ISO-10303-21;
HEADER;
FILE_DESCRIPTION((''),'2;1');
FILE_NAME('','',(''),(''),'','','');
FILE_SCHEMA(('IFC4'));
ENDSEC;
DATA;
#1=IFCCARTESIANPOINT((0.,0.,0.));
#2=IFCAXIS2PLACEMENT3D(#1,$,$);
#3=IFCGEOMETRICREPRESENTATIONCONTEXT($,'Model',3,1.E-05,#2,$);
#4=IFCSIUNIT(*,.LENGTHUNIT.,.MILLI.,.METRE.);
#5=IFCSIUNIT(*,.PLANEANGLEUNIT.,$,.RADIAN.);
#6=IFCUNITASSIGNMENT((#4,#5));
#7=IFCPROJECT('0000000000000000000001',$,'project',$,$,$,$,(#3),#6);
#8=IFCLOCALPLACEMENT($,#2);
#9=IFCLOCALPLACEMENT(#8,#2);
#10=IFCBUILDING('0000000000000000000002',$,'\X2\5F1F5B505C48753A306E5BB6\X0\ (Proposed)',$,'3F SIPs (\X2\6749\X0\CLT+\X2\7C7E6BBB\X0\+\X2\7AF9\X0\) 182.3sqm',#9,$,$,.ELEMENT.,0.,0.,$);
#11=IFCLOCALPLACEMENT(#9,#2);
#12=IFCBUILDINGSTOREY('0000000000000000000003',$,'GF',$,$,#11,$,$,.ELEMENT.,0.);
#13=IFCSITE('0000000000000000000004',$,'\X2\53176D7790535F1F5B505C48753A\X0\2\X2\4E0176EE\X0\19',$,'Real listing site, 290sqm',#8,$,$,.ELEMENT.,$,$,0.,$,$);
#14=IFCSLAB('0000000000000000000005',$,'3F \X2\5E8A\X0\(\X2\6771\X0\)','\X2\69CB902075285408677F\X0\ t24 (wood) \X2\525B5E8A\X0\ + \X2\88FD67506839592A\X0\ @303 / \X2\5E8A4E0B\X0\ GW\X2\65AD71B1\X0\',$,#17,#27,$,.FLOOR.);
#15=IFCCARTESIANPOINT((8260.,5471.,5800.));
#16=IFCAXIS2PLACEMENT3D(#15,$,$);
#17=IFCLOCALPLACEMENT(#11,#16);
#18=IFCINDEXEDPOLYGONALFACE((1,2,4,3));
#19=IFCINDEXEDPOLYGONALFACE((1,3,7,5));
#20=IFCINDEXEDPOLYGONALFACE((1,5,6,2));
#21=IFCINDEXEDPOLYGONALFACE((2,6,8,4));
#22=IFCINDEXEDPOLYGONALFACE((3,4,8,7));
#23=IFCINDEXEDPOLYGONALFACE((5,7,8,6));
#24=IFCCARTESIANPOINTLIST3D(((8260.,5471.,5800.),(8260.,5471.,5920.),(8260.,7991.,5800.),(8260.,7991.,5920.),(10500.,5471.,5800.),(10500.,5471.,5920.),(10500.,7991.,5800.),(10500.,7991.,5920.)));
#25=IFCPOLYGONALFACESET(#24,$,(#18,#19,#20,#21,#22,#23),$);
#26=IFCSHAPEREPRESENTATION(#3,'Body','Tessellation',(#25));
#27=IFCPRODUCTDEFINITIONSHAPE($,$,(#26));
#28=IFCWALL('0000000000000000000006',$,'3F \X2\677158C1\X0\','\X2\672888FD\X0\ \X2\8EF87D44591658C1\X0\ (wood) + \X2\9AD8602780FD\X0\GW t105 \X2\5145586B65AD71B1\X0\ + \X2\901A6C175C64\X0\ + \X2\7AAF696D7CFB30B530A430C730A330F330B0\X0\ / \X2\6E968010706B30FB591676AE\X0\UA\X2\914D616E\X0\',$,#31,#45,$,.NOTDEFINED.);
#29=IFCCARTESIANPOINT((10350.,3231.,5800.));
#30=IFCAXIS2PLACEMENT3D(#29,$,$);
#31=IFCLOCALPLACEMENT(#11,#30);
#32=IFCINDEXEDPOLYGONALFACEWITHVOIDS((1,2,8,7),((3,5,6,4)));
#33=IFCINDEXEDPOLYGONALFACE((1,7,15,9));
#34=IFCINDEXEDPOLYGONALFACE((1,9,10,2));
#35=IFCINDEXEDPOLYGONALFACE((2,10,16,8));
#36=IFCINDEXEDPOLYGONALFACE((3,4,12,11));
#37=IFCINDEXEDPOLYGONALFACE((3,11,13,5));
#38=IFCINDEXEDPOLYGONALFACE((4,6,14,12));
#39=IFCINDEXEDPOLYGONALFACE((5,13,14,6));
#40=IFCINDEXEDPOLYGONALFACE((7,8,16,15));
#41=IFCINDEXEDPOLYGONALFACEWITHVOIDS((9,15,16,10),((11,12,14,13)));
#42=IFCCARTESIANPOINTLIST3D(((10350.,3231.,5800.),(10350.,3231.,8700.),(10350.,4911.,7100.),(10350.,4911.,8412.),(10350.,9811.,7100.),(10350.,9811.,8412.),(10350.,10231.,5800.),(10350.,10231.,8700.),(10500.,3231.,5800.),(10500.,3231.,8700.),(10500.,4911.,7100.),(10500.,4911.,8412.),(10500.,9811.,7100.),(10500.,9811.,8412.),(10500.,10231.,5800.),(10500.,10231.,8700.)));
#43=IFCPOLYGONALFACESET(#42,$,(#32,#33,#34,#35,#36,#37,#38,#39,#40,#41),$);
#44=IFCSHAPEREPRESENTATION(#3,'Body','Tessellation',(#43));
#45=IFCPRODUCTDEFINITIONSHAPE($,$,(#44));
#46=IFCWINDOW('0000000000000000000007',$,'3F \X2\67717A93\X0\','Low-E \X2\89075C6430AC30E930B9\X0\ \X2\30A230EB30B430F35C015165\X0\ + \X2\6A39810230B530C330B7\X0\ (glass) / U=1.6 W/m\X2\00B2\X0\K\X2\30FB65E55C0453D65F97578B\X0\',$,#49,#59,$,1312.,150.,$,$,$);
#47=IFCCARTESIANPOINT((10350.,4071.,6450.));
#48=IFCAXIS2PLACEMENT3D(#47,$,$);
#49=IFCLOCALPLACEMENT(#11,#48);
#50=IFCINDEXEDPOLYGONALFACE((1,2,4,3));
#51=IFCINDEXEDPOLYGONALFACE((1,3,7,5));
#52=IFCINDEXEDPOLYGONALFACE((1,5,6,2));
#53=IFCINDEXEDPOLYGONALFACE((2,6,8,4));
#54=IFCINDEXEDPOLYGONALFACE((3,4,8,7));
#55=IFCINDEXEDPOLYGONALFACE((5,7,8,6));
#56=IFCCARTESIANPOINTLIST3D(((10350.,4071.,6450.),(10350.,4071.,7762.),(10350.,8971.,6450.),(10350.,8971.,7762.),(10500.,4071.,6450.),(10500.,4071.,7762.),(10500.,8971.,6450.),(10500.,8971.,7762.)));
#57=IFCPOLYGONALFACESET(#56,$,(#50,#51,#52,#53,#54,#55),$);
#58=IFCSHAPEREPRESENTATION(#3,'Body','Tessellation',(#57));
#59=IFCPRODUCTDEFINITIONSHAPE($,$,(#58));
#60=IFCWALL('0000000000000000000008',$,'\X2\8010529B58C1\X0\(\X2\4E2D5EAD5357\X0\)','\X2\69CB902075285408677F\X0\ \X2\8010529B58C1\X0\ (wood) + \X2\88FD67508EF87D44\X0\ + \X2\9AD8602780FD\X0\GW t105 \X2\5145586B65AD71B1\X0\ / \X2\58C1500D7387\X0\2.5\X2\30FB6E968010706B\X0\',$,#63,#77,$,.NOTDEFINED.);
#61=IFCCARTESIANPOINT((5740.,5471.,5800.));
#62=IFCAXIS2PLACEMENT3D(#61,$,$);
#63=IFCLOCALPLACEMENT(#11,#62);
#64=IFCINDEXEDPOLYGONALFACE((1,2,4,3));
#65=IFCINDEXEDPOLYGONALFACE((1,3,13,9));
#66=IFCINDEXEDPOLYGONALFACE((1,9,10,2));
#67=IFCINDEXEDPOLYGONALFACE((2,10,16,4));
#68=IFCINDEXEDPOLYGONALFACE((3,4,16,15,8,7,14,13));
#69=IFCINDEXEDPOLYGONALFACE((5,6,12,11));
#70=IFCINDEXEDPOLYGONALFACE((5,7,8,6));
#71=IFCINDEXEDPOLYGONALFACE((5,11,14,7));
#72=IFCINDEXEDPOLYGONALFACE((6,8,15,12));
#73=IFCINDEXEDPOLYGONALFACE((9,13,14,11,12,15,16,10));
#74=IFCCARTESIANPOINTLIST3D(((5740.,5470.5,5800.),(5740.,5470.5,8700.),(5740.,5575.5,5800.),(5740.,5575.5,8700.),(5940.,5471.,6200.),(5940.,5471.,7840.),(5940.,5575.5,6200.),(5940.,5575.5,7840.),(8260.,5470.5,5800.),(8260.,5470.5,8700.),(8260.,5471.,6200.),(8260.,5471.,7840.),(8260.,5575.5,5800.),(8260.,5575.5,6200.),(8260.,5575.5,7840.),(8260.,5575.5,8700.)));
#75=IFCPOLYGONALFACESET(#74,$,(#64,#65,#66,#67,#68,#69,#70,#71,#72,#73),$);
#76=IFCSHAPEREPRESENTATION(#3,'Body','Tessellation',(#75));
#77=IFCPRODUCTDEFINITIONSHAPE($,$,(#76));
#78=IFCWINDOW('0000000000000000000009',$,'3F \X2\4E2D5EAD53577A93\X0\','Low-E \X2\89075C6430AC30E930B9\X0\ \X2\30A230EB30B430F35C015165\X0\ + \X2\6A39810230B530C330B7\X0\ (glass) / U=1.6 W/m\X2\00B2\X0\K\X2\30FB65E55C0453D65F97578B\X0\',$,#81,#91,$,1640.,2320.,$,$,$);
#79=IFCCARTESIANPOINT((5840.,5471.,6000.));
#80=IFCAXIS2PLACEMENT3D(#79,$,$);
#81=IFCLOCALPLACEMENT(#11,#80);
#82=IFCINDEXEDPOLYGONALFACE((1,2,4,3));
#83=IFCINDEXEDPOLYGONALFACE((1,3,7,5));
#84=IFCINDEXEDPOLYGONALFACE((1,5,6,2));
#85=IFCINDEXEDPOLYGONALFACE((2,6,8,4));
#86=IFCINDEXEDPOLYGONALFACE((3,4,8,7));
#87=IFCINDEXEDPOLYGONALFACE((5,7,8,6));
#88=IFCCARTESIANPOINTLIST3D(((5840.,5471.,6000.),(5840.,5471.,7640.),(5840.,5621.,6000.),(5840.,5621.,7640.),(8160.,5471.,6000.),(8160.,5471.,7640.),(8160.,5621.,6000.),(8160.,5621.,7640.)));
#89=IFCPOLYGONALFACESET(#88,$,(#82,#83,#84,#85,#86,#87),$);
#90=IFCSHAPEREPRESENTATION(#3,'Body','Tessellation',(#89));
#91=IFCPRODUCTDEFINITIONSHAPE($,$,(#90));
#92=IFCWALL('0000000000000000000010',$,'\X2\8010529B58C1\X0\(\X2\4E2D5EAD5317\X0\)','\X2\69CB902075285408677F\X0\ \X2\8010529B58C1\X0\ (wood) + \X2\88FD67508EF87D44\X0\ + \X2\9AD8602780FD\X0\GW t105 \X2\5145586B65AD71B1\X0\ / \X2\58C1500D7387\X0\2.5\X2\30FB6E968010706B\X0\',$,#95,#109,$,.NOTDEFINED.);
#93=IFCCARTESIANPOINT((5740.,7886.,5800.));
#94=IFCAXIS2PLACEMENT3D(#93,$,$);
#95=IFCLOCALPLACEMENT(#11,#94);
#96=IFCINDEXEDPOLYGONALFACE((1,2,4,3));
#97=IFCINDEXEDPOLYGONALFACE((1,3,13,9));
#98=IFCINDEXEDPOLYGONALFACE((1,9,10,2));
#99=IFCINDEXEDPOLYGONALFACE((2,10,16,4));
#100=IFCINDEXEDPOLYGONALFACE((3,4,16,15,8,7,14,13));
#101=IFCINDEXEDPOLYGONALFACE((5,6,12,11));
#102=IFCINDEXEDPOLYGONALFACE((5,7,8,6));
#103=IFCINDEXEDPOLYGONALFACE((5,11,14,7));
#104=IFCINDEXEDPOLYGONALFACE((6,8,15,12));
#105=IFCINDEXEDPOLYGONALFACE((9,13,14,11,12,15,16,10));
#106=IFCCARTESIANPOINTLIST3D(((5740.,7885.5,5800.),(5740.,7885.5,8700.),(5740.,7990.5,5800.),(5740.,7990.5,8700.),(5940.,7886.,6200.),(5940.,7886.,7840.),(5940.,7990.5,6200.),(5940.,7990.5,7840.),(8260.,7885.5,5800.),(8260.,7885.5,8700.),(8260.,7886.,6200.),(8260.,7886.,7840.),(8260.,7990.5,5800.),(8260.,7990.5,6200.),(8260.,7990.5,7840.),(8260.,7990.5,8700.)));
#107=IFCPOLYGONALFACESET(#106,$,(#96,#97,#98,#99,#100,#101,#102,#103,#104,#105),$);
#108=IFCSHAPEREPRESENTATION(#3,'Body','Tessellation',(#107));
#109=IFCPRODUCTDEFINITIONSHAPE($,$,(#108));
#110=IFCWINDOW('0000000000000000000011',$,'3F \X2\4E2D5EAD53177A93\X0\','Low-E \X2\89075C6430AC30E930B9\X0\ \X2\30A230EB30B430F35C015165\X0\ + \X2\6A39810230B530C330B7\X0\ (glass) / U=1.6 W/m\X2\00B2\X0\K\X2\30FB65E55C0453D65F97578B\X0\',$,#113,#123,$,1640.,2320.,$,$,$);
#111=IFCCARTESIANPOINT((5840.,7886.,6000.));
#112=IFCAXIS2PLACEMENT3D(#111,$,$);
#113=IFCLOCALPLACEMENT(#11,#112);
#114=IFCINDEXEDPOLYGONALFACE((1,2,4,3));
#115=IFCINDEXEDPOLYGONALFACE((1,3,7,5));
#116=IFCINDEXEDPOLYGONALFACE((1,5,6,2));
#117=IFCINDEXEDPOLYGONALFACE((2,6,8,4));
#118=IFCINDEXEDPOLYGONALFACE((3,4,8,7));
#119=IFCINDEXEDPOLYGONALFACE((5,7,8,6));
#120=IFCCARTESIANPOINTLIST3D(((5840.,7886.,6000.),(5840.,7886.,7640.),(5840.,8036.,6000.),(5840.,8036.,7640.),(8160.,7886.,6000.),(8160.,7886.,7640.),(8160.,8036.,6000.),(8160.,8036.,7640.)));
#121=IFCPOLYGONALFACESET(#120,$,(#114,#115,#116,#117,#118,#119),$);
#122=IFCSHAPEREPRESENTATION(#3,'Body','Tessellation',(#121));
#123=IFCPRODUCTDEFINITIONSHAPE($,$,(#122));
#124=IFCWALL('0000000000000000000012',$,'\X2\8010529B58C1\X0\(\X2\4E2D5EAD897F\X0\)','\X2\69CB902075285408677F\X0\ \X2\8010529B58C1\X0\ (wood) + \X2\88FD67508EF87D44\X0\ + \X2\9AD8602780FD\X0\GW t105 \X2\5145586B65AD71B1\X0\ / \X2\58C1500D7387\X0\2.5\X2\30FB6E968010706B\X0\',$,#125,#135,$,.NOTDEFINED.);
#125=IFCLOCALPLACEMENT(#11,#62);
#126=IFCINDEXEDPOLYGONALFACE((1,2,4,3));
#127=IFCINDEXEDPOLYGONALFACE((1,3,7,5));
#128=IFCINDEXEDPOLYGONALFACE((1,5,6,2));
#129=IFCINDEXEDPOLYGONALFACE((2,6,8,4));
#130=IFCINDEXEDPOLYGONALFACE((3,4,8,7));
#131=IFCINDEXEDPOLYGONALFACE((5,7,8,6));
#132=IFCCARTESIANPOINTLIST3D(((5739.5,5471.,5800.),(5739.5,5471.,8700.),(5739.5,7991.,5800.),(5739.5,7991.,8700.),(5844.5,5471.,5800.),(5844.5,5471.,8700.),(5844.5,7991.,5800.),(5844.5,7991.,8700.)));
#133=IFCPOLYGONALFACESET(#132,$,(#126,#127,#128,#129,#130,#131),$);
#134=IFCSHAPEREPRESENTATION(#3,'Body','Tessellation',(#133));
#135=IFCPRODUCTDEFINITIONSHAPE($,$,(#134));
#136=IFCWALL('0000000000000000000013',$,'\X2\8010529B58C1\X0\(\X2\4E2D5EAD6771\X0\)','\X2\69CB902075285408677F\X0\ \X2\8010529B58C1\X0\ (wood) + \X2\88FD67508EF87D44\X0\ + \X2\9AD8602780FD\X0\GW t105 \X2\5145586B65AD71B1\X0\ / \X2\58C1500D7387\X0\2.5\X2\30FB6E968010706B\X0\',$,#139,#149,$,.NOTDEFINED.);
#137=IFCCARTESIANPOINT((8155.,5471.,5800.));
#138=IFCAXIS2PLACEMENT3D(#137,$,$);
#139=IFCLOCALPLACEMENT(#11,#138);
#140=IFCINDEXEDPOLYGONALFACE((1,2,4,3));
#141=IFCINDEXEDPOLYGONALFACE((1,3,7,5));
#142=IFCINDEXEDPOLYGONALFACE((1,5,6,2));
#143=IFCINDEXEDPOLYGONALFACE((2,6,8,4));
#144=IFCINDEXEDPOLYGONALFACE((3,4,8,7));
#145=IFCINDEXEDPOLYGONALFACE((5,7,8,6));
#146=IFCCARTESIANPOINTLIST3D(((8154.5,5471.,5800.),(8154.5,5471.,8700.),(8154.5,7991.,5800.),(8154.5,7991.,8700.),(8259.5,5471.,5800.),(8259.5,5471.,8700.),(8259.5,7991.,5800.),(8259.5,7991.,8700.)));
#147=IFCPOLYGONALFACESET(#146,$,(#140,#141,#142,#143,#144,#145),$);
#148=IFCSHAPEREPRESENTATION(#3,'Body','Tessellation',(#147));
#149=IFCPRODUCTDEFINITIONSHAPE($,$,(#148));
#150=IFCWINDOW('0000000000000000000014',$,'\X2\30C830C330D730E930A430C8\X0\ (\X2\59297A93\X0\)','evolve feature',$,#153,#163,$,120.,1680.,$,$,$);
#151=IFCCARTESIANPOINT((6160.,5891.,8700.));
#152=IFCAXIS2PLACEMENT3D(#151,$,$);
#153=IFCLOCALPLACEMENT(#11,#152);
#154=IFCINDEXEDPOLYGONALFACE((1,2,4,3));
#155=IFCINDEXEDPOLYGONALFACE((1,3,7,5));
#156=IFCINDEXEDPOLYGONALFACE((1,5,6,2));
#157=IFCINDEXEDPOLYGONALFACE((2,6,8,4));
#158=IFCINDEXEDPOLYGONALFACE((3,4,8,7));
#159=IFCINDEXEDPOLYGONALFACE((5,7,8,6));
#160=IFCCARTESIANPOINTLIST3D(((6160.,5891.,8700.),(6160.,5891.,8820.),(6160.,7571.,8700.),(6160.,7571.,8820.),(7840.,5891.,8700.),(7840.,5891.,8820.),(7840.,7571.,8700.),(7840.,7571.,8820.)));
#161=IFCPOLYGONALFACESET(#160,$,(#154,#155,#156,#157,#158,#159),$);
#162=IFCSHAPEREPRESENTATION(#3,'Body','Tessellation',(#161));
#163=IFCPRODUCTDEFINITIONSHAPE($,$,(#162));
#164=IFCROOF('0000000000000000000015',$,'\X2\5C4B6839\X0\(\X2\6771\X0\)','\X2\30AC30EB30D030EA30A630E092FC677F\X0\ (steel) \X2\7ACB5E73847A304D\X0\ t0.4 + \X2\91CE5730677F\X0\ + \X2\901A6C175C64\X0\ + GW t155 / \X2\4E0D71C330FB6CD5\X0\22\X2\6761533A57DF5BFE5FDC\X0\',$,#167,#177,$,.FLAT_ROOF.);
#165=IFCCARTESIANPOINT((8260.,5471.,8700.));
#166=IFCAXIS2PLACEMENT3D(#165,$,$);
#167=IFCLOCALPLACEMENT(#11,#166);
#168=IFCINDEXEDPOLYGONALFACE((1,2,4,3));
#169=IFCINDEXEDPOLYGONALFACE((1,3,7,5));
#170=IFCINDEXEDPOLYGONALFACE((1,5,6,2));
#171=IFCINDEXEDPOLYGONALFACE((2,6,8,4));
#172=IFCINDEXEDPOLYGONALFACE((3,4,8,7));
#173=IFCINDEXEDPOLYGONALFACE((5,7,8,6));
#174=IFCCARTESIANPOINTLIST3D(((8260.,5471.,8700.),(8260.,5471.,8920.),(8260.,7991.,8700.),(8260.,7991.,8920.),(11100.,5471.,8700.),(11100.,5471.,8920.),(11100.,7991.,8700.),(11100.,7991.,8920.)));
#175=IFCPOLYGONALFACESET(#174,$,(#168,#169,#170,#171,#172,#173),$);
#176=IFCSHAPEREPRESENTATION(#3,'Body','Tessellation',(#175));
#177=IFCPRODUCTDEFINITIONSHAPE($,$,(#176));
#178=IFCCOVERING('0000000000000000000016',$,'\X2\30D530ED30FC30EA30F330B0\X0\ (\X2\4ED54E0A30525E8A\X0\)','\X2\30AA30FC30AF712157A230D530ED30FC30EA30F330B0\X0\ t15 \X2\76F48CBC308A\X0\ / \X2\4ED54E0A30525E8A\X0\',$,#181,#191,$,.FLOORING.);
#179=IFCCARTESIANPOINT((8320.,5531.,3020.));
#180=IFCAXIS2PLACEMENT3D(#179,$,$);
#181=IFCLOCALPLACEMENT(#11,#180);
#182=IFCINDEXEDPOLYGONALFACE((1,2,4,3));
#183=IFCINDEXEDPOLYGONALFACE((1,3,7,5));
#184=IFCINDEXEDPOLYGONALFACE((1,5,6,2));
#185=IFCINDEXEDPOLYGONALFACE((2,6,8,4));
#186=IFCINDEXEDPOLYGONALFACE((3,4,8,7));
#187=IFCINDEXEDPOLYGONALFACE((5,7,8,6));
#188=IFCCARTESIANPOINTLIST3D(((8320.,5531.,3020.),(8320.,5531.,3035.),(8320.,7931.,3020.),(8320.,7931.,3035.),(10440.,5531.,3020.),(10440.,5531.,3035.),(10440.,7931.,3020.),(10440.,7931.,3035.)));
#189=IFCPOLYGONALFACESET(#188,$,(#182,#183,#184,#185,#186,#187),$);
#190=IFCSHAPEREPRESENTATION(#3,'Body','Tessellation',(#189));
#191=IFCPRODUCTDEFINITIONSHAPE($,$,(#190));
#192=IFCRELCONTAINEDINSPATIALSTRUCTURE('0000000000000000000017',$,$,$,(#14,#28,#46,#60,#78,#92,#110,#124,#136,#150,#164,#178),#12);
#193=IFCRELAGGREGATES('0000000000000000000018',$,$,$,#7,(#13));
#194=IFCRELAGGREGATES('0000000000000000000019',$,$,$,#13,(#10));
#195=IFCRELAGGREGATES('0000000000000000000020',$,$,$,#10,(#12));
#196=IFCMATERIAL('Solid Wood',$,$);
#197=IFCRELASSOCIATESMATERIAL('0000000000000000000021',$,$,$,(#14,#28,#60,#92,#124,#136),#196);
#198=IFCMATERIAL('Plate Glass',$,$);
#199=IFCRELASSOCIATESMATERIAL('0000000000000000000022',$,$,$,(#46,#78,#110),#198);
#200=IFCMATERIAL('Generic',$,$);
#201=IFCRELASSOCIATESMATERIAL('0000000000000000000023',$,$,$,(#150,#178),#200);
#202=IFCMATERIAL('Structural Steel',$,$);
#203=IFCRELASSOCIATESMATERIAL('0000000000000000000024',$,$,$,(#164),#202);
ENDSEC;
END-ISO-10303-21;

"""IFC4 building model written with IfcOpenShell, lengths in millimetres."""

from ifc_helpers import new_model, si_unit, frame, frame_2d, origin, place, context, project, spatial, rectangle, extrude, material, element, fill, save


model = new_model("IFC4")

# Units and contexts
model_context = context("Model", 3, precision=1e-05, world=origin())
ifc_project = project(units=[si_unit("LENGTHUNIT", "METRE", prefix="MILLI"), si_unit("PLANEANGLEUNIT", "RADIAN")], contexts=[model_context])

# Site, building, storey
site_placement = place(None, origin())
site = spatial("IfcSite", under=ifc_project, at=site_placement, Name="北海道弟子屈町2丁目19", ObjectType="Real listing site, 290sqm", CompositionType="ELEMENT", RefElevation=0.0)
building_placement = place(site_placement, origin())
building = spatial("IfcBuilding", under=site, at=building_placement, Name="弟子屈町の家 (Proposed)", ObjectType="3F SIPs (杉CLT+籾殻+竹) 182.3sqm", CompositionType="ELEMENT", ElevationOfRefHeight=0.0, ElevationOfTerrain=0.0)
storey_placement = place(building_placement, origin())
storey = spatial("IfcBuildingStorey", under=building, at=storey_placement, Name="GF", CompositionType="ELEMENT", Elevation=0.0)

# Slab
ifc_material_1 = material(Name="Solid Wood")
slab_placement = place(storey_placement, frame((8260.0, 5471.0, 5800.0)))
element("IfcSlab", 1, at=slab_placement, inside=storey, material=ifc_material_1, Name="3F 床(東)", Description="構造用合板 t24 (wood) 剛床 + 製材根太 @303 / 床下 GW断熱", PredefinedType="FLOOR", context=model_context, shape_type="SweptSolid", body=[
    extrude(rectangle(XDim=2240.0, YDim=2520.0, at=frame_2d((1120.0, 1260.0))), frame((8260.0, 5471.0, 5800.0)), (0.0, 0.0, 1.0), 120.0),
])

# Walls, openings, windows
wall_1_placement = place(storey_placement, frame((10350.0, 3231.0, 5800.0)))
wall_1 = element("IfcWall", 2, at=wall_1_placement, inside=storey, material=ifc_material_1, Name="3F 東壁", Description="木製 軸組外壁 (wood) + 高性能GW t105 充填断熱 + 通気層 + 窯業系サイディング / 準耐火・外皮UA配慮", PredefinedType="NOTDEFINED", context=model_context, shape_type="SweptSolid", body=[
    extrude(rectangle(XDim=150.0, YDim=7000.0, at=frame_2d((75.0, 3500.0))), frame((10350.0, 3231.0, 5800.0)), (0.0, 0.0, 1.0), 2900.0),
])
opening_1_placement = place(storey_placement, frame((10350.0, 4071.0, 6450.0)))
opening_1 = element("IfcOpeningElement", 3, at=opening_1_placement, cuts=wall_1, PredefinedType="NOTDEFINED", context=model_context, shape_type="SweptSolid", body=[
    extrude(rectangle(XDim=150.0, YDim=4900.0, at=frame_2d((75.0, 2450.0))), frame((10350.0, 4071.0, 6450.0)), (0.0, 0.0, 1.0), 1312.0),
])
ifc_material_2 = material(Name="Plate Glass")
window_1_placement = place(storey_placement, frame((10350.0, 4071.0, 6450.0)))
window_1 = element("IfcWindow", 4, at=window_1_placement, inside=storey, material=ifc_material_2, Name="3F 東窓", Description="Low-E 複層ガラス アルゴン封入 + 樹脂サッシ (glass) / U=1.6 W/m²K・日射取得型", OverallHeight=1312.0, OverallWidth=150.0, context=model_context, shape_type="SweptSolid", body=[
    extrude(rectangle(XDim=150.0, YDim=4900.0, at=frame_2d((75.0, 2450.0))), frame((10350.0, 4071.0, 6450.0)), (0.0, 0.0, 1.0), 1312.0),
])
fill(opening_1, window_1)
wall_2_placement = place(storey_placement, frame((5740.0, 5471.0, 5800.0)))
wall_2 = element("IfcWall", 5, at=wall_2_placement, inside=storey, material=ifc_material_1, Name="耐力壁(中庭南)", Description="構造用合板 耐力壁 (wood) + 製材軸組 + 高性能GW t105 充填断熱 / 壁倍率2.5・準耐火", PredefinedType="NOTDEFINED", context=model_context, shape_type="SweptSolid", body=[
    extrude(rectangle(XDim=2520.0, YDim=105.0, at=frame_2d((1260.0, 52.0))), frame((5740.0, 5471.0, 5800.0)), (0.0, 0.0, 1.0), 2900.0),
])
opening_2_placement = place(storey_placement, frame((5840.0, 5471.0, 6000.0)))
opening_2 = element("IfcOpeningElement", 6, at=opening_2_placement, cuts=wall_2, PredefinedType="NOTDEFINED", context=model_context, shape_type="SweptSolid", body=[
    extrude(rectangle(XDim=2320.0, YDim=150.0, at=frame_2d((1160.0, 75.0))), frame((5840.0, 5471.0, 6000.0)), (0.0, 0.0, 1.0), 1640.0),
])
window_2_placement = place(storey_placement, frame((5840.0, 5471.0, 6000.0)))
window_2 = element("IfcWindow", 7, at=window_2_placement, inside=storey, material=ifc_material_2, Name="3F 中庭南窓", Description="Low-E 複層ガラス アルゴン封入 + 樹脂サッシ (glass) / U=1.6 W/m²K・日射取得型", OverallHeight=1640.0, OverallWidth=2320.0, context=model_context, shape_type="SweptSolid", body=[
    extrude(rectangle(XDim=2320.0, YDim=150.0, at=frame_2d((1160.0, 75.0))), frame((5840.0, 5471.0, 6000.0)), (0.0, 0.0, 1.0), 1640.0),
])
fill(opening_2, window_2)
wall_3_placement = place(storey_placement, frame((5740.0, 7886.0, 5800.0)))
wall_3 = element("IfcWall", 8, at=wall_3_placement, inside=storey, material=ifc_material_1, Name="耐力壁(中庭北)", Description="構造用合板 耐力壁 (wood) + 製材軸組 + 高性能GW t105 充填断熱 / 壁倍率2.5・準耐火", PredefinedType="NOTDEFINED", context=model_context, shape_type="SweptSolid", body=[
    extrude(rectangle(XDim=2520.0, YDim=105.0, at=frame_2d((1260.0, 52.0))), frame((5740.0, 7886.0, 5800.0)), (0.0, 0.0, 1.0), 2900.0),
])
opening_3_placement = place(storey_placement, frame((5840.0, 7886.0, 6000.0)))
opening_3 = element("IfcOpeningElement", 9, at=opening_3_placement, cuts=wall_3, PredefinedType="NOTDEFINED", context=model_context, shape_type="SweptSolid", body=[
    extrude(rectangle(XDim=2320.0, YDim=150.0, at=frame_2d((1160.0, 75.0))), frame((5840.0, 7886.0, 6000.0)), (0.0, 0.0, 1.0), 1640.0),
])
window_3_placement = place(storey_placement, frame((5840.0, 7886.0, 6000.0)))
window_3 = element("IfcWindow", 10, at=window_3_placement, inside=storey, material=ifc_material_2, Name="3F 中庭北窓", Description="Low-E 複層ガラス アルゴン封入 + 樹脂サッシ (glass) / U=1.6 W/m²K・日射取得型", OverallHeight=1640.0, OverallWidth=2320.0, context=model_context, shape_type="SweptSolid", body=[
    extrude(rectangle(XDim=2320.0, YDim=150.0, at=frame_2d((1160.0, 75.0))), frame((5840.0, 7886.0, 6000.0)), (0.0, 0.0, 1.0), 1640.0),
])
fill(opening_3, window_3)

# Walls
wall_4_placement = place(storey_placement, frame((5740.0, 5471.0, 5800.0)))
element("IfcWall", 11, at=wall_4_placement, inside=storey, material=ifc_material_1, Name="耐力壁(中庭西)", Description="構造用合板 耐力壁 (wood) + 製材軸組 + 高性能GW t105 充填断熱 / 壁倍率2.5・準耐火", PredefinedType="NOTDEFINED", context=model_context, shape_type="SweptSolid", body=[
    extrude(rectangle(XDim=105.0, YDim=2520.0, at=frame_2d((52.0, 1260.0))), frame((5740.0, 5471.0, 5800.0)), (0.0, 0.0, 1.0), 2900.0),
])
wall_5_placement = place(storey_placement, frame((8155.0, 5471.0, 5800.0)))
element("IfcWall", 12, at=wall_5_placement, inside=storey, material=ifc_material_1, Name="耐力壁(中庭東)", Description="構造用合板 耐力壁 (wood) + 製材軸組 + 高性能GW t105 充填断熱 / 壁倍率2.5・準耐火", PredefinedType="NOTDEFINED", context=model_context, shape_type="SweptSolid", body=[
    extrude(rectangle(XDim=105.0, YDim=2520.0, at=frame_2d((52.0, 1260.0))), frame((8155.0, 5471.0, 5800.0)), (0.0, 0.0, 1.0), 2900.0),
])

# Window
ifc_material_3 = material(Name="Generic")
window_4_placement = place(storey_placement, frame((6160.0, 5891.0, 8700.0)))
element("IfcWindow", 13, at=window_4_placement, inside=storey, material=ifc_material_3, Name="トップライト (天窓)", Description="evolve feature", OverallHeight=120.0, OverallWidth=1680.0, context=model_context, shape_type="SweptSolid", body=[
    extrude(rectangle(XDim=1680.0, YDim=1680.0, at=frame_2d((840.0, 840.0))), frame((6160.0, 5891.0, 8700.0)), (0.0, 0.0, 1.0), 120.0),
])

# Roof
ifc_material_4 = material(Name="Structural Steel")
for number, where, name in (
    (14, (8260.0, 5471.0, 8700.0), "屋根(東)"),
):
    element("IfcRoof", number, at=place(storey_placement, frame(where)), inside=storey, material=ifc_material_4, Name=name, Description="ガルバリウム鋼板 (steel) 立平葺き t0.4 + 野地板 + 通気層 + GW t155 / 不燃・法22条区域対応", PredefinedType="FLAT_ROOF", context=model_context, shape_type="SweptSolid", body=[
        extrude(rectangle(XDim=2840.0, YDim=2520.0, at=frame_2d((1420.0, 1260.0))), frame((8260.0, 5471.0, 8700.0)), (0.0, 0.0, 1.0), 220.0),
    ])

# Covering
covering_1_placement = place(storey_placement, frame((8320.0, 5531.0, 3020.0)))
element("IfcCovering", 15, at=covering_1_placement, inside=storey, material=ifc_material_3, Name="フローリング (仕上げ床)", Description="オーク無垢フローリング t15 直貼り / 仕上げ床", PredefinedType="FLOORING", context=model_context, shape_type="SweptSolid", body=[
    extrude(rectangle(XDim=2120.0, YDim=2400.0, at=frame_2d((1060.0, 1200.0))), frame((8320.0, 5531.0, 3020.0)), (0.0, 0.0, 1.0), 15.0),
])

save(model, "model.ifc")
